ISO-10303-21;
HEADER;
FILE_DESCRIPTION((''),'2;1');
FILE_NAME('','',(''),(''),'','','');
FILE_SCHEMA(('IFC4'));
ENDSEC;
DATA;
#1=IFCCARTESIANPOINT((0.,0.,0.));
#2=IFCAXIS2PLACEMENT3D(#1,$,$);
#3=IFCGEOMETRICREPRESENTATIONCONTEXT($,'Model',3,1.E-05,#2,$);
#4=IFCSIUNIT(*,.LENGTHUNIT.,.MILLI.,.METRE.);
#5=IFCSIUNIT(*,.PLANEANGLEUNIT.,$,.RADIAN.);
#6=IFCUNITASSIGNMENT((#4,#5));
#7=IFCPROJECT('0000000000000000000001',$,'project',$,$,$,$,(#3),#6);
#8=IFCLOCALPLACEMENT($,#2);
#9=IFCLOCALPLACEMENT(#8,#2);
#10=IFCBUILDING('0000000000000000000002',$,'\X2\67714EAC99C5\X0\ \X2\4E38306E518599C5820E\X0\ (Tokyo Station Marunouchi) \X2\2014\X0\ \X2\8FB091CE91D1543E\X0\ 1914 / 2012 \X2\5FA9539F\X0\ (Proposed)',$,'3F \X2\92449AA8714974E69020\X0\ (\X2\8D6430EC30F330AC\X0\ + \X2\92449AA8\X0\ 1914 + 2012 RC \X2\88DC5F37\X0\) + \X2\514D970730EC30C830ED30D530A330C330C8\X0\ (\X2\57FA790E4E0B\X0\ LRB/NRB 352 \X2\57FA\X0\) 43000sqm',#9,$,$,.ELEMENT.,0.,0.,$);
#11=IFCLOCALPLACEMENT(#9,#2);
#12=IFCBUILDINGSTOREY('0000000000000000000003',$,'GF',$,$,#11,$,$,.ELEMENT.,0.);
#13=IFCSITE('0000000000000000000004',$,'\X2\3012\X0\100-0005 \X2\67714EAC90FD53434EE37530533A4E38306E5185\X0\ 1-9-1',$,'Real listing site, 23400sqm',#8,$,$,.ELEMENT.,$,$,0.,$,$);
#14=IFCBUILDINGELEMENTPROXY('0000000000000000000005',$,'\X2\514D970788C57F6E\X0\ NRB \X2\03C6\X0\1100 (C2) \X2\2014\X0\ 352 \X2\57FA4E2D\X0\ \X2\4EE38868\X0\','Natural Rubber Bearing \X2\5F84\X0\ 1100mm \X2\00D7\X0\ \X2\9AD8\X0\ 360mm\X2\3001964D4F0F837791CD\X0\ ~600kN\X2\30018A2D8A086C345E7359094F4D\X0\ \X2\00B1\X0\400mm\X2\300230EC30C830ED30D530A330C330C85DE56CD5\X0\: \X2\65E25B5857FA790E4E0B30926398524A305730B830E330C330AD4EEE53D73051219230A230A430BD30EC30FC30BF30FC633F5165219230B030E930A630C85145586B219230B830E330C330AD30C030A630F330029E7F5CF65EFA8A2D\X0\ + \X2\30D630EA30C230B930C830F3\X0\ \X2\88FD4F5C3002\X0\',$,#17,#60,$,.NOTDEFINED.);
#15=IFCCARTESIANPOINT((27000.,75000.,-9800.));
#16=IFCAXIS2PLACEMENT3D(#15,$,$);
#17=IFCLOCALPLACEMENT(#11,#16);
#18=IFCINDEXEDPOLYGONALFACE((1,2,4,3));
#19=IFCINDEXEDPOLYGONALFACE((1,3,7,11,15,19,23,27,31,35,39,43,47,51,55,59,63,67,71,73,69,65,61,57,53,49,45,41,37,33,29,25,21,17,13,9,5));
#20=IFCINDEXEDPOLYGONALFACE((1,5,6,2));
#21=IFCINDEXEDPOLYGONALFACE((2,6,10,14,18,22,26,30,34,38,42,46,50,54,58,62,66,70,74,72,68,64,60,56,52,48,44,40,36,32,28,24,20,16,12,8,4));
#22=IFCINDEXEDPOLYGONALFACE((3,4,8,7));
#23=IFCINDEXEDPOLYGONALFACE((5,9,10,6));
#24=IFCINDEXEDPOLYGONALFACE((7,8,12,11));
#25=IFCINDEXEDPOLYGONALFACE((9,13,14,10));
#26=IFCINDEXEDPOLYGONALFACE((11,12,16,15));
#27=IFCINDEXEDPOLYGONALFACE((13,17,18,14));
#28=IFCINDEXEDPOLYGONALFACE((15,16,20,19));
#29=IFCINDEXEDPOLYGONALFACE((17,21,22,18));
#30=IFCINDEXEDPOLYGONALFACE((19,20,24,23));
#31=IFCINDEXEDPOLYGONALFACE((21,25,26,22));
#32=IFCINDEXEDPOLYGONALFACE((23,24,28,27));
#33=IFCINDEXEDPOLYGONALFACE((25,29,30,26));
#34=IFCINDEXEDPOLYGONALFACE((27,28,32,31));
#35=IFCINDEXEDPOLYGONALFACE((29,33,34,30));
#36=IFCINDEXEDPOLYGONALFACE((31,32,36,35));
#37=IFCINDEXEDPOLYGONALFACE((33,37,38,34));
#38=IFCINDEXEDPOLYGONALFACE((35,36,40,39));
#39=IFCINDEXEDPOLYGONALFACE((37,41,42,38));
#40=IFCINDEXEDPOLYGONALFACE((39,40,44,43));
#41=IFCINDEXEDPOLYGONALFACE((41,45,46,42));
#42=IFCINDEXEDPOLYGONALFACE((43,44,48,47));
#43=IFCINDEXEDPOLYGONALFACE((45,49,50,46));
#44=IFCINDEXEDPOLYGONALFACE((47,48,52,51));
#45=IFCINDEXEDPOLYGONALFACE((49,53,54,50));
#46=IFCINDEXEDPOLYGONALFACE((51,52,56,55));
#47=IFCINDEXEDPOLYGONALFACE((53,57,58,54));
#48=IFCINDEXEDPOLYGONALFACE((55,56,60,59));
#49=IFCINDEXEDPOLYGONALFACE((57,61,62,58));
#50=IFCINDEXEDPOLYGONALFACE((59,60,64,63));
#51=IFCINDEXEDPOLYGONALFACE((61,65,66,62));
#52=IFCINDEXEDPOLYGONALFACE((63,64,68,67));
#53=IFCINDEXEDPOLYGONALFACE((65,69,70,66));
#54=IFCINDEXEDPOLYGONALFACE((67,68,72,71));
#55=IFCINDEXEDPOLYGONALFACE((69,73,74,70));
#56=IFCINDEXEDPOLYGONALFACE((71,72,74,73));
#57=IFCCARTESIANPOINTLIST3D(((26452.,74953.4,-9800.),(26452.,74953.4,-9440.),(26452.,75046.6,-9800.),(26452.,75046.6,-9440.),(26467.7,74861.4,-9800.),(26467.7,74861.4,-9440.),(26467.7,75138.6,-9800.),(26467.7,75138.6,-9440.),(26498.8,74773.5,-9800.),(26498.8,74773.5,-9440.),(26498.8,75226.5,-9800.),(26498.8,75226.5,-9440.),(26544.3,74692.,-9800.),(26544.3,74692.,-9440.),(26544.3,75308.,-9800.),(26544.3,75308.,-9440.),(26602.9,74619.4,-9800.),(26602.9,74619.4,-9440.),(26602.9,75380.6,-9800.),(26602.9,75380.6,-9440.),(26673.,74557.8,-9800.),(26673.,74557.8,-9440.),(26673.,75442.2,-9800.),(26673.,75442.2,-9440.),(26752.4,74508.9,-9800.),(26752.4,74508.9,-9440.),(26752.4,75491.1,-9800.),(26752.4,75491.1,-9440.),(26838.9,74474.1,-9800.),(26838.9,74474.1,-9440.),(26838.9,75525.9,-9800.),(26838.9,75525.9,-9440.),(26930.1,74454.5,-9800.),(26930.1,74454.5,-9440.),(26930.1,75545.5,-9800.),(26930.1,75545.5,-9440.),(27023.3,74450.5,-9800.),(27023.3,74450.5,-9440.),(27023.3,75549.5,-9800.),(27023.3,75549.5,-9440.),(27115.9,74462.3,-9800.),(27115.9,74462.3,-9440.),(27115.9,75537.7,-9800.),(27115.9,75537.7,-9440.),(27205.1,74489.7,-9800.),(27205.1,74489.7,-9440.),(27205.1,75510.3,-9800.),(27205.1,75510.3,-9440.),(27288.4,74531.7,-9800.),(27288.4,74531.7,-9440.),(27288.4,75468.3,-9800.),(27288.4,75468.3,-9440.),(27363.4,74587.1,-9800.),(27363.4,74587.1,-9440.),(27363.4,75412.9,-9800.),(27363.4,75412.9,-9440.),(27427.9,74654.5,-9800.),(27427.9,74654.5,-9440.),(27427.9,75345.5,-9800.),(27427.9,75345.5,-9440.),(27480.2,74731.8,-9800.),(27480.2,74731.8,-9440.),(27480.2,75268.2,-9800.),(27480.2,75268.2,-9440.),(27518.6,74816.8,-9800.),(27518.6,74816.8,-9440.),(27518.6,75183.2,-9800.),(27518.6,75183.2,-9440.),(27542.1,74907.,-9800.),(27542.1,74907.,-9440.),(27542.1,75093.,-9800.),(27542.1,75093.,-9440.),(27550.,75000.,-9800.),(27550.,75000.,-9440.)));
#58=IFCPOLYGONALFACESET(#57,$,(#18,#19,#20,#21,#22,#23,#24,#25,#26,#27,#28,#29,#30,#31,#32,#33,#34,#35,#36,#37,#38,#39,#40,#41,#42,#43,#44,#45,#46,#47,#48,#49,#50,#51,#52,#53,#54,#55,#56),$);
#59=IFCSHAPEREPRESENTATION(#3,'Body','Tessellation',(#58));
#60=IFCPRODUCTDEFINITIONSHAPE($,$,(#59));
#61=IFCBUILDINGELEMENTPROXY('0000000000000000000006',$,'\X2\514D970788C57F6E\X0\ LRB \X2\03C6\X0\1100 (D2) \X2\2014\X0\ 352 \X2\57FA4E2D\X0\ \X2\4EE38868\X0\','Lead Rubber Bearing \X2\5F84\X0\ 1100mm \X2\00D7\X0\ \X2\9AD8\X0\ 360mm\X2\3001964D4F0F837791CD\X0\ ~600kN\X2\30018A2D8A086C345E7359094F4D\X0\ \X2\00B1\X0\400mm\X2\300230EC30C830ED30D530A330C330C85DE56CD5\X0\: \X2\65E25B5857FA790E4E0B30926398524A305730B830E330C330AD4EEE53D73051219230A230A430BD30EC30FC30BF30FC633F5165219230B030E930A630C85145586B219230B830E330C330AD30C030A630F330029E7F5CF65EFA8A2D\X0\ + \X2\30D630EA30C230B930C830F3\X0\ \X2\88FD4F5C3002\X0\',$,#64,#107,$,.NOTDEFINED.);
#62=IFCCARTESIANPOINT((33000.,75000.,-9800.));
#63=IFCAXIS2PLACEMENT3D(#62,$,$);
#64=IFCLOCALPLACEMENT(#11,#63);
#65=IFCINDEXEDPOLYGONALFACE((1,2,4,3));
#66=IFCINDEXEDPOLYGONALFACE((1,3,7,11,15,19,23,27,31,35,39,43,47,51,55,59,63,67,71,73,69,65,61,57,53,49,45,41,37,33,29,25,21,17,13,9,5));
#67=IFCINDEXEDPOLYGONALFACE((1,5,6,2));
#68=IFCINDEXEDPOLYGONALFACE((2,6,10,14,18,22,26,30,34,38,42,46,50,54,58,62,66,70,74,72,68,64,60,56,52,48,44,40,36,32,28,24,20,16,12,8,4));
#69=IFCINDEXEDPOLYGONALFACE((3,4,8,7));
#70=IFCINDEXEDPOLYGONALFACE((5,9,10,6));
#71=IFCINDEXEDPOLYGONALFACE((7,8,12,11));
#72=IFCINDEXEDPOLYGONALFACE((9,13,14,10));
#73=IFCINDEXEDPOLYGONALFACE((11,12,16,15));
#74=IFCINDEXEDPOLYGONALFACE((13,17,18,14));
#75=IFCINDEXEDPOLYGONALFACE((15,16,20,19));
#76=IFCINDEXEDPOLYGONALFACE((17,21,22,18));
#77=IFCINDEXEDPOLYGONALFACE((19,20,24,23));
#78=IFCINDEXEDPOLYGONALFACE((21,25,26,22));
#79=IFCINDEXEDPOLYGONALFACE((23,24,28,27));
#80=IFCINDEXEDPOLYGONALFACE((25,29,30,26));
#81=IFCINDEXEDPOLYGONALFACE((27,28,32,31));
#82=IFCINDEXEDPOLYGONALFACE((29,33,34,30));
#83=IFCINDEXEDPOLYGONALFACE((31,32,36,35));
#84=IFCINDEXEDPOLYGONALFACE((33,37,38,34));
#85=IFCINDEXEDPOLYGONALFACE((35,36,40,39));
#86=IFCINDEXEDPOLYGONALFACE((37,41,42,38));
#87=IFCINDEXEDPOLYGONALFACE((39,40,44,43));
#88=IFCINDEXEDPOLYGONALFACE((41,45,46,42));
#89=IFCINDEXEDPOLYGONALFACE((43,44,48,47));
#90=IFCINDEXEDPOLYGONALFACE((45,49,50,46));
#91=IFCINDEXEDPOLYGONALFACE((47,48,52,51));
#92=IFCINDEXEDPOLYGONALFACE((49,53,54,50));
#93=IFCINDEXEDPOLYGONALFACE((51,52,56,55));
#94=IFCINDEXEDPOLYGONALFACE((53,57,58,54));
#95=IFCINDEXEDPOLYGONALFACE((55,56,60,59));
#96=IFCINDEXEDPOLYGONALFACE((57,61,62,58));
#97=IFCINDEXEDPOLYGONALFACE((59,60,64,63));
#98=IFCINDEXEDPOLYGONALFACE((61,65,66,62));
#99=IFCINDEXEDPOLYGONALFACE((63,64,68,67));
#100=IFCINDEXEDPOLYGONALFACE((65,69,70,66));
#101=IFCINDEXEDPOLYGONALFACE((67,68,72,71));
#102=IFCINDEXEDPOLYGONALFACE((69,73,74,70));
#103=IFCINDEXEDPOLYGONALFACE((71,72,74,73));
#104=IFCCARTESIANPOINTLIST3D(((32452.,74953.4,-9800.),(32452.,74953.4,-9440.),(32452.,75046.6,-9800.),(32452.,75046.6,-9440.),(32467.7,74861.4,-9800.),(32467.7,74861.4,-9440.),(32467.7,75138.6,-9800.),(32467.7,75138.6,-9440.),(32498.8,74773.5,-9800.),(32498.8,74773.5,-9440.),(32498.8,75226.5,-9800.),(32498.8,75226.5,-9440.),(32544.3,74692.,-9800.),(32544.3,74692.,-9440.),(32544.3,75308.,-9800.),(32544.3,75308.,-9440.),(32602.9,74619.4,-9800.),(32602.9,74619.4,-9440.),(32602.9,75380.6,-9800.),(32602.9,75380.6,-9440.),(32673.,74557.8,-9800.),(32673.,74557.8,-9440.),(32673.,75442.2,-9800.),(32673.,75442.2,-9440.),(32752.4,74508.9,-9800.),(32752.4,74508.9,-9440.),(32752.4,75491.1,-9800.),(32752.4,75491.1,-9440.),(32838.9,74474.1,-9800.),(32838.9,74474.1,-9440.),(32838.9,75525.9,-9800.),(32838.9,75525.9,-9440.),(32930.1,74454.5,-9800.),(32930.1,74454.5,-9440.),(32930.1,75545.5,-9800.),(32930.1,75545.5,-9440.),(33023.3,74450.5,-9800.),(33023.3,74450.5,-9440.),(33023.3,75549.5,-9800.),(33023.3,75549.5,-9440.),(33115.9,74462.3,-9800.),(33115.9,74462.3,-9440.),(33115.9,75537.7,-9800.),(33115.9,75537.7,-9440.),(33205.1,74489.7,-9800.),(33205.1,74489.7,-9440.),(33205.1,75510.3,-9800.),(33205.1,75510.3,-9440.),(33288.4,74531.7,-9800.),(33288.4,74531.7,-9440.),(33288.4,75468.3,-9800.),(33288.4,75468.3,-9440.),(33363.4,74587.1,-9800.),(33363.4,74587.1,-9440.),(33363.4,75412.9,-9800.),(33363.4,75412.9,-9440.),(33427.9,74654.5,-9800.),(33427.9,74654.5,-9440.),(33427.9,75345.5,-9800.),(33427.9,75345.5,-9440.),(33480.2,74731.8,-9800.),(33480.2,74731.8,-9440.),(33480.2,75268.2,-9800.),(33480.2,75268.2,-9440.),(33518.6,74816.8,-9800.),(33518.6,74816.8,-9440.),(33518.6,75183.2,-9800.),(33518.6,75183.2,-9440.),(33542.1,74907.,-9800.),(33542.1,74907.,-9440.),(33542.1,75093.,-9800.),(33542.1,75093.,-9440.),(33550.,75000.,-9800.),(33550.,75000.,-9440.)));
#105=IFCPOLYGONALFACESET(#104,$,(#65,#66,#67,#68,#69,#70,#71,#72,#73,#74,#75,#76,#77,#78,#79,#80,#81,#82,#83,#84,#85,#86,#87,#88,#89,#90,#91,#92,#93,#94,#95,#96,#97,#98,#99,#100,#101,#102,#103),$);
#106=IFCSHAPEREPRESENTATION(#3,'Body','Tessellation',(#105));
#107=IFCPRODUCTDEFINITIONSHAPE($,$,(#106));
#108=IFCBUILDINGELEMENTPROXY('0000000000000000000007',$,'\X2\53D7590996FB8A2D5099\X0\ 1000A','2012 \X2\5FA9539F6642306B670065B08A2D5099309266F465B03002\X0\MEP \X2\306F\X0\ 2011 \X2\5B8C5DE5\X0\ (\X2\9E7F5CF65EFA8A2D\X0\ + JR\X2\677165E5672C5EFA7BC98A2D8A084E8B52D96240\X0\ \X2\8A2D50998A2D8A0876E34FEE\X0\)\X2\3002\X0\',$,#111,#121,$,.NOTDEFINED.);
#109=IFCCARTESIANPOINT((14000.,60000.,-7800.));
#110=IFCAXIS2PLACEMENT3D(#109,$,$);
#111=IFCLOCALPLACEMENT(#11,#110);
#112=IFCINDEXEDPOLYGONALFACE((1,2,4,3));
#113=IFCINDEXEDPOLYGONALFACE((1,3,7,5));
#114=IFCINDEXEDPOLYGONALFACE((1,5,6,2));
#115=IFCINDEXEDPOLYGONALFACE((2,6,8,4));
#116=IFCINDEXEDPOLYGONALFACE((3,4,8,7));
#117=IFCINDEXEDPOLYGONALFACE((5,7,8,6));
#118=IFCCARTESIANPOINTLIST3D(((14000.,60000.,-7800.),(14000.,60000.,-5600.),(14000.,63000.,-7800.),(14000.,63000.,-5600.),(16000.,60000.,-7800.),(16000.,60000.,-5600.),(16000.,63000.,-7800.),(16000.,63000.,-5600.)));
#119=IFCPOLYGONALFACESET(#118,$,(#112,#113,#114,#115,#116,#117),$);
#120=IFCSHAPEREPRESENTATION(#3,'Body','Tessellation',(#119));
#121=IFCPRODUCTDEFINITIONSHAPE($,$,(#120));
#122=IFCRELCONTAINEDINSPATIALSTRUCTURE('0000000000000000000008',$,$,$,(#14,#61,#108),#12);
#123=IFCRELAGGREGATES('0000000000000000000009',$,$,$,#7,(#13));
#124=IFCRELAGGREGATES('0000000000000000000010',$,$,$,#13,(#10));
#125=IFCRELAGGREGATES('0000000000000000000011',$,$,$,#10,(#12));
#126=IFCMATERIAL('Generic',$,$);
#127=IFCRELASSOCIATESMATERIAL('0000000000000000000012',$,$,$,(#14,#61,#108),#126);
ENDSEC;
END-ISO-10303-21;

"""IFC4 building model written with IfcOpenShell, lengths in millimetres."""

from ifc_helpers import new_model, si_unit, frame, frame_2d, origin, origin_2d, place, context, project, spatial, rectangle, circle, extrude, material, element, save


model = new_model("IFC4")

# Units and contexts
model_context = context("Model", 3, precision=1e-05, world=origin())
ifc_project = project(units=[si_unit("LENGTHUNIT", "METRE", prefix="MILLI"), si_unit("PLANEANGLEUNIT", "RADIAN")], contexts=[model_context])

# Site, building, storey
site_placement = place(None, origin())
site = spatial("IfcSite", under=ifc_project, at=site_placement, Name="〒100-0005 東京都千代田区丸の内 1-9-1", ObjectType="Real listing site, 23400sqm", CompositionType="ELEMENT", RefElevation=0.0)
building_placement = place(site_placement, origin())
building = spatial("IfcBuilding", under=site, at=building_placement, Name="東京駅 丸の内駅舎 (Tokyo Station Marunouchi) — 辰野金吾 1914 / 2012 復原 (Proposed)", ObjectType="3F 鉄骨煉瓦造 (赤レンガ + 鉄骨 1914 + 2012 RC 補強) + 免震レトロフィット (基礎下 LRB/NRB 352 基) 43000sqm", CompositionType="ELEMENT", ElevationOfRefHeight=0.0, ElevationOfTerrain=0.0)
storey_placement = place(building_placement, origin())
storey = spatial("IfcBuildingStorey", under=building, at=storey_placement, Name="GF", CompositionType="ELEMENT", Elevation=0.0)

# Building element proxies
ifc_material_1 = material(Name="Generic")
proxy_1_placement = place(storey_placement, frame((27000.0, 75000.0, -9800.0)))
element("IfcBuildingElementProxy", 1, at=proxy_1_placement, inside=storey, material=ifc_material_1, Name="免震装置 NRB φ1100 (C2) — 352 基中 代表", Description="Natural Rubber Bearing 径 1100mm × 高 360mm、降伏荷重 ~600kN、設計水平変位 ±400mm。レトロフィット工法: 既存基礎下を掘削しジャッキ仮受け→アイソレーター挿入→グラウト充填→ジャッキダウン。鹿島建設 + ブリヂストン 製作。", PredefinedType="NOTDEFINED", context=model_context, shape_type="SweptSolid", body=[
    extrude(circle(Radius=550.0, at=origin_2d()), frame((27000.0, 75000.0, -9800.0)), (0.0, 0.0, 1.0), 360.0),
])
proxy_2_placement = place(storey_placement, frame((33000.0, 75000.0, -9800.0)))
element("IfcBuildingElementProxy", 2, at=proxy_2_placement, inside=storey, material=ifc_material_1, Name="免震装置 LRB φ1100 (D2) — 352 基中 代表", Description="Lead Rubber Bearing 径 1100mm × 高 360mm、降伏荷重 ~600kN、設計水平変位 ±400mm。レトロフィット工法: 既存基礎下を掘削しジャッキ仮受け→アイソレーター挿入→グラウト充填→ジャッキダウン。鹿島建設 + ブリヂストン 製作。", PredefinedType="NOTDEFINED", context=model_context, shape_type="SweptSolid", body=[
    extrude(circle(Radius=550.0, at=origin_2d()), frame((33000.0, 75000.0, -9800.0)), (0.0, 0.0, 1.0), 360.0),
])
proxy_3_placement = place(storey_placement, frame((14000.0, 60000.0, -7800.0)))
element("IfcBuildingElementProxy", 3, at=proxy_3_placement, inside=storey, material=ifc_material_1, Name="受変電設備 1000A", Description="2012 復原時に最新設備を更新。MEP は 2011 完工 (鹿島建設 + JR東日本建築設計事務所 設備設計監修)。", PredefinedType="NOTDEFINED", context=model_context, shape_type="SweptSolid", body=[
    extrude(rectangle(XDim=2000.0, YDim=3000.0, at=frame_2d((1000.0, 1500.0))), frame((14000.0, 60000.0, -7800.0)), (0.0, 0.0, 1.0), 2200.0),
])

save(model, "model.ifc")
